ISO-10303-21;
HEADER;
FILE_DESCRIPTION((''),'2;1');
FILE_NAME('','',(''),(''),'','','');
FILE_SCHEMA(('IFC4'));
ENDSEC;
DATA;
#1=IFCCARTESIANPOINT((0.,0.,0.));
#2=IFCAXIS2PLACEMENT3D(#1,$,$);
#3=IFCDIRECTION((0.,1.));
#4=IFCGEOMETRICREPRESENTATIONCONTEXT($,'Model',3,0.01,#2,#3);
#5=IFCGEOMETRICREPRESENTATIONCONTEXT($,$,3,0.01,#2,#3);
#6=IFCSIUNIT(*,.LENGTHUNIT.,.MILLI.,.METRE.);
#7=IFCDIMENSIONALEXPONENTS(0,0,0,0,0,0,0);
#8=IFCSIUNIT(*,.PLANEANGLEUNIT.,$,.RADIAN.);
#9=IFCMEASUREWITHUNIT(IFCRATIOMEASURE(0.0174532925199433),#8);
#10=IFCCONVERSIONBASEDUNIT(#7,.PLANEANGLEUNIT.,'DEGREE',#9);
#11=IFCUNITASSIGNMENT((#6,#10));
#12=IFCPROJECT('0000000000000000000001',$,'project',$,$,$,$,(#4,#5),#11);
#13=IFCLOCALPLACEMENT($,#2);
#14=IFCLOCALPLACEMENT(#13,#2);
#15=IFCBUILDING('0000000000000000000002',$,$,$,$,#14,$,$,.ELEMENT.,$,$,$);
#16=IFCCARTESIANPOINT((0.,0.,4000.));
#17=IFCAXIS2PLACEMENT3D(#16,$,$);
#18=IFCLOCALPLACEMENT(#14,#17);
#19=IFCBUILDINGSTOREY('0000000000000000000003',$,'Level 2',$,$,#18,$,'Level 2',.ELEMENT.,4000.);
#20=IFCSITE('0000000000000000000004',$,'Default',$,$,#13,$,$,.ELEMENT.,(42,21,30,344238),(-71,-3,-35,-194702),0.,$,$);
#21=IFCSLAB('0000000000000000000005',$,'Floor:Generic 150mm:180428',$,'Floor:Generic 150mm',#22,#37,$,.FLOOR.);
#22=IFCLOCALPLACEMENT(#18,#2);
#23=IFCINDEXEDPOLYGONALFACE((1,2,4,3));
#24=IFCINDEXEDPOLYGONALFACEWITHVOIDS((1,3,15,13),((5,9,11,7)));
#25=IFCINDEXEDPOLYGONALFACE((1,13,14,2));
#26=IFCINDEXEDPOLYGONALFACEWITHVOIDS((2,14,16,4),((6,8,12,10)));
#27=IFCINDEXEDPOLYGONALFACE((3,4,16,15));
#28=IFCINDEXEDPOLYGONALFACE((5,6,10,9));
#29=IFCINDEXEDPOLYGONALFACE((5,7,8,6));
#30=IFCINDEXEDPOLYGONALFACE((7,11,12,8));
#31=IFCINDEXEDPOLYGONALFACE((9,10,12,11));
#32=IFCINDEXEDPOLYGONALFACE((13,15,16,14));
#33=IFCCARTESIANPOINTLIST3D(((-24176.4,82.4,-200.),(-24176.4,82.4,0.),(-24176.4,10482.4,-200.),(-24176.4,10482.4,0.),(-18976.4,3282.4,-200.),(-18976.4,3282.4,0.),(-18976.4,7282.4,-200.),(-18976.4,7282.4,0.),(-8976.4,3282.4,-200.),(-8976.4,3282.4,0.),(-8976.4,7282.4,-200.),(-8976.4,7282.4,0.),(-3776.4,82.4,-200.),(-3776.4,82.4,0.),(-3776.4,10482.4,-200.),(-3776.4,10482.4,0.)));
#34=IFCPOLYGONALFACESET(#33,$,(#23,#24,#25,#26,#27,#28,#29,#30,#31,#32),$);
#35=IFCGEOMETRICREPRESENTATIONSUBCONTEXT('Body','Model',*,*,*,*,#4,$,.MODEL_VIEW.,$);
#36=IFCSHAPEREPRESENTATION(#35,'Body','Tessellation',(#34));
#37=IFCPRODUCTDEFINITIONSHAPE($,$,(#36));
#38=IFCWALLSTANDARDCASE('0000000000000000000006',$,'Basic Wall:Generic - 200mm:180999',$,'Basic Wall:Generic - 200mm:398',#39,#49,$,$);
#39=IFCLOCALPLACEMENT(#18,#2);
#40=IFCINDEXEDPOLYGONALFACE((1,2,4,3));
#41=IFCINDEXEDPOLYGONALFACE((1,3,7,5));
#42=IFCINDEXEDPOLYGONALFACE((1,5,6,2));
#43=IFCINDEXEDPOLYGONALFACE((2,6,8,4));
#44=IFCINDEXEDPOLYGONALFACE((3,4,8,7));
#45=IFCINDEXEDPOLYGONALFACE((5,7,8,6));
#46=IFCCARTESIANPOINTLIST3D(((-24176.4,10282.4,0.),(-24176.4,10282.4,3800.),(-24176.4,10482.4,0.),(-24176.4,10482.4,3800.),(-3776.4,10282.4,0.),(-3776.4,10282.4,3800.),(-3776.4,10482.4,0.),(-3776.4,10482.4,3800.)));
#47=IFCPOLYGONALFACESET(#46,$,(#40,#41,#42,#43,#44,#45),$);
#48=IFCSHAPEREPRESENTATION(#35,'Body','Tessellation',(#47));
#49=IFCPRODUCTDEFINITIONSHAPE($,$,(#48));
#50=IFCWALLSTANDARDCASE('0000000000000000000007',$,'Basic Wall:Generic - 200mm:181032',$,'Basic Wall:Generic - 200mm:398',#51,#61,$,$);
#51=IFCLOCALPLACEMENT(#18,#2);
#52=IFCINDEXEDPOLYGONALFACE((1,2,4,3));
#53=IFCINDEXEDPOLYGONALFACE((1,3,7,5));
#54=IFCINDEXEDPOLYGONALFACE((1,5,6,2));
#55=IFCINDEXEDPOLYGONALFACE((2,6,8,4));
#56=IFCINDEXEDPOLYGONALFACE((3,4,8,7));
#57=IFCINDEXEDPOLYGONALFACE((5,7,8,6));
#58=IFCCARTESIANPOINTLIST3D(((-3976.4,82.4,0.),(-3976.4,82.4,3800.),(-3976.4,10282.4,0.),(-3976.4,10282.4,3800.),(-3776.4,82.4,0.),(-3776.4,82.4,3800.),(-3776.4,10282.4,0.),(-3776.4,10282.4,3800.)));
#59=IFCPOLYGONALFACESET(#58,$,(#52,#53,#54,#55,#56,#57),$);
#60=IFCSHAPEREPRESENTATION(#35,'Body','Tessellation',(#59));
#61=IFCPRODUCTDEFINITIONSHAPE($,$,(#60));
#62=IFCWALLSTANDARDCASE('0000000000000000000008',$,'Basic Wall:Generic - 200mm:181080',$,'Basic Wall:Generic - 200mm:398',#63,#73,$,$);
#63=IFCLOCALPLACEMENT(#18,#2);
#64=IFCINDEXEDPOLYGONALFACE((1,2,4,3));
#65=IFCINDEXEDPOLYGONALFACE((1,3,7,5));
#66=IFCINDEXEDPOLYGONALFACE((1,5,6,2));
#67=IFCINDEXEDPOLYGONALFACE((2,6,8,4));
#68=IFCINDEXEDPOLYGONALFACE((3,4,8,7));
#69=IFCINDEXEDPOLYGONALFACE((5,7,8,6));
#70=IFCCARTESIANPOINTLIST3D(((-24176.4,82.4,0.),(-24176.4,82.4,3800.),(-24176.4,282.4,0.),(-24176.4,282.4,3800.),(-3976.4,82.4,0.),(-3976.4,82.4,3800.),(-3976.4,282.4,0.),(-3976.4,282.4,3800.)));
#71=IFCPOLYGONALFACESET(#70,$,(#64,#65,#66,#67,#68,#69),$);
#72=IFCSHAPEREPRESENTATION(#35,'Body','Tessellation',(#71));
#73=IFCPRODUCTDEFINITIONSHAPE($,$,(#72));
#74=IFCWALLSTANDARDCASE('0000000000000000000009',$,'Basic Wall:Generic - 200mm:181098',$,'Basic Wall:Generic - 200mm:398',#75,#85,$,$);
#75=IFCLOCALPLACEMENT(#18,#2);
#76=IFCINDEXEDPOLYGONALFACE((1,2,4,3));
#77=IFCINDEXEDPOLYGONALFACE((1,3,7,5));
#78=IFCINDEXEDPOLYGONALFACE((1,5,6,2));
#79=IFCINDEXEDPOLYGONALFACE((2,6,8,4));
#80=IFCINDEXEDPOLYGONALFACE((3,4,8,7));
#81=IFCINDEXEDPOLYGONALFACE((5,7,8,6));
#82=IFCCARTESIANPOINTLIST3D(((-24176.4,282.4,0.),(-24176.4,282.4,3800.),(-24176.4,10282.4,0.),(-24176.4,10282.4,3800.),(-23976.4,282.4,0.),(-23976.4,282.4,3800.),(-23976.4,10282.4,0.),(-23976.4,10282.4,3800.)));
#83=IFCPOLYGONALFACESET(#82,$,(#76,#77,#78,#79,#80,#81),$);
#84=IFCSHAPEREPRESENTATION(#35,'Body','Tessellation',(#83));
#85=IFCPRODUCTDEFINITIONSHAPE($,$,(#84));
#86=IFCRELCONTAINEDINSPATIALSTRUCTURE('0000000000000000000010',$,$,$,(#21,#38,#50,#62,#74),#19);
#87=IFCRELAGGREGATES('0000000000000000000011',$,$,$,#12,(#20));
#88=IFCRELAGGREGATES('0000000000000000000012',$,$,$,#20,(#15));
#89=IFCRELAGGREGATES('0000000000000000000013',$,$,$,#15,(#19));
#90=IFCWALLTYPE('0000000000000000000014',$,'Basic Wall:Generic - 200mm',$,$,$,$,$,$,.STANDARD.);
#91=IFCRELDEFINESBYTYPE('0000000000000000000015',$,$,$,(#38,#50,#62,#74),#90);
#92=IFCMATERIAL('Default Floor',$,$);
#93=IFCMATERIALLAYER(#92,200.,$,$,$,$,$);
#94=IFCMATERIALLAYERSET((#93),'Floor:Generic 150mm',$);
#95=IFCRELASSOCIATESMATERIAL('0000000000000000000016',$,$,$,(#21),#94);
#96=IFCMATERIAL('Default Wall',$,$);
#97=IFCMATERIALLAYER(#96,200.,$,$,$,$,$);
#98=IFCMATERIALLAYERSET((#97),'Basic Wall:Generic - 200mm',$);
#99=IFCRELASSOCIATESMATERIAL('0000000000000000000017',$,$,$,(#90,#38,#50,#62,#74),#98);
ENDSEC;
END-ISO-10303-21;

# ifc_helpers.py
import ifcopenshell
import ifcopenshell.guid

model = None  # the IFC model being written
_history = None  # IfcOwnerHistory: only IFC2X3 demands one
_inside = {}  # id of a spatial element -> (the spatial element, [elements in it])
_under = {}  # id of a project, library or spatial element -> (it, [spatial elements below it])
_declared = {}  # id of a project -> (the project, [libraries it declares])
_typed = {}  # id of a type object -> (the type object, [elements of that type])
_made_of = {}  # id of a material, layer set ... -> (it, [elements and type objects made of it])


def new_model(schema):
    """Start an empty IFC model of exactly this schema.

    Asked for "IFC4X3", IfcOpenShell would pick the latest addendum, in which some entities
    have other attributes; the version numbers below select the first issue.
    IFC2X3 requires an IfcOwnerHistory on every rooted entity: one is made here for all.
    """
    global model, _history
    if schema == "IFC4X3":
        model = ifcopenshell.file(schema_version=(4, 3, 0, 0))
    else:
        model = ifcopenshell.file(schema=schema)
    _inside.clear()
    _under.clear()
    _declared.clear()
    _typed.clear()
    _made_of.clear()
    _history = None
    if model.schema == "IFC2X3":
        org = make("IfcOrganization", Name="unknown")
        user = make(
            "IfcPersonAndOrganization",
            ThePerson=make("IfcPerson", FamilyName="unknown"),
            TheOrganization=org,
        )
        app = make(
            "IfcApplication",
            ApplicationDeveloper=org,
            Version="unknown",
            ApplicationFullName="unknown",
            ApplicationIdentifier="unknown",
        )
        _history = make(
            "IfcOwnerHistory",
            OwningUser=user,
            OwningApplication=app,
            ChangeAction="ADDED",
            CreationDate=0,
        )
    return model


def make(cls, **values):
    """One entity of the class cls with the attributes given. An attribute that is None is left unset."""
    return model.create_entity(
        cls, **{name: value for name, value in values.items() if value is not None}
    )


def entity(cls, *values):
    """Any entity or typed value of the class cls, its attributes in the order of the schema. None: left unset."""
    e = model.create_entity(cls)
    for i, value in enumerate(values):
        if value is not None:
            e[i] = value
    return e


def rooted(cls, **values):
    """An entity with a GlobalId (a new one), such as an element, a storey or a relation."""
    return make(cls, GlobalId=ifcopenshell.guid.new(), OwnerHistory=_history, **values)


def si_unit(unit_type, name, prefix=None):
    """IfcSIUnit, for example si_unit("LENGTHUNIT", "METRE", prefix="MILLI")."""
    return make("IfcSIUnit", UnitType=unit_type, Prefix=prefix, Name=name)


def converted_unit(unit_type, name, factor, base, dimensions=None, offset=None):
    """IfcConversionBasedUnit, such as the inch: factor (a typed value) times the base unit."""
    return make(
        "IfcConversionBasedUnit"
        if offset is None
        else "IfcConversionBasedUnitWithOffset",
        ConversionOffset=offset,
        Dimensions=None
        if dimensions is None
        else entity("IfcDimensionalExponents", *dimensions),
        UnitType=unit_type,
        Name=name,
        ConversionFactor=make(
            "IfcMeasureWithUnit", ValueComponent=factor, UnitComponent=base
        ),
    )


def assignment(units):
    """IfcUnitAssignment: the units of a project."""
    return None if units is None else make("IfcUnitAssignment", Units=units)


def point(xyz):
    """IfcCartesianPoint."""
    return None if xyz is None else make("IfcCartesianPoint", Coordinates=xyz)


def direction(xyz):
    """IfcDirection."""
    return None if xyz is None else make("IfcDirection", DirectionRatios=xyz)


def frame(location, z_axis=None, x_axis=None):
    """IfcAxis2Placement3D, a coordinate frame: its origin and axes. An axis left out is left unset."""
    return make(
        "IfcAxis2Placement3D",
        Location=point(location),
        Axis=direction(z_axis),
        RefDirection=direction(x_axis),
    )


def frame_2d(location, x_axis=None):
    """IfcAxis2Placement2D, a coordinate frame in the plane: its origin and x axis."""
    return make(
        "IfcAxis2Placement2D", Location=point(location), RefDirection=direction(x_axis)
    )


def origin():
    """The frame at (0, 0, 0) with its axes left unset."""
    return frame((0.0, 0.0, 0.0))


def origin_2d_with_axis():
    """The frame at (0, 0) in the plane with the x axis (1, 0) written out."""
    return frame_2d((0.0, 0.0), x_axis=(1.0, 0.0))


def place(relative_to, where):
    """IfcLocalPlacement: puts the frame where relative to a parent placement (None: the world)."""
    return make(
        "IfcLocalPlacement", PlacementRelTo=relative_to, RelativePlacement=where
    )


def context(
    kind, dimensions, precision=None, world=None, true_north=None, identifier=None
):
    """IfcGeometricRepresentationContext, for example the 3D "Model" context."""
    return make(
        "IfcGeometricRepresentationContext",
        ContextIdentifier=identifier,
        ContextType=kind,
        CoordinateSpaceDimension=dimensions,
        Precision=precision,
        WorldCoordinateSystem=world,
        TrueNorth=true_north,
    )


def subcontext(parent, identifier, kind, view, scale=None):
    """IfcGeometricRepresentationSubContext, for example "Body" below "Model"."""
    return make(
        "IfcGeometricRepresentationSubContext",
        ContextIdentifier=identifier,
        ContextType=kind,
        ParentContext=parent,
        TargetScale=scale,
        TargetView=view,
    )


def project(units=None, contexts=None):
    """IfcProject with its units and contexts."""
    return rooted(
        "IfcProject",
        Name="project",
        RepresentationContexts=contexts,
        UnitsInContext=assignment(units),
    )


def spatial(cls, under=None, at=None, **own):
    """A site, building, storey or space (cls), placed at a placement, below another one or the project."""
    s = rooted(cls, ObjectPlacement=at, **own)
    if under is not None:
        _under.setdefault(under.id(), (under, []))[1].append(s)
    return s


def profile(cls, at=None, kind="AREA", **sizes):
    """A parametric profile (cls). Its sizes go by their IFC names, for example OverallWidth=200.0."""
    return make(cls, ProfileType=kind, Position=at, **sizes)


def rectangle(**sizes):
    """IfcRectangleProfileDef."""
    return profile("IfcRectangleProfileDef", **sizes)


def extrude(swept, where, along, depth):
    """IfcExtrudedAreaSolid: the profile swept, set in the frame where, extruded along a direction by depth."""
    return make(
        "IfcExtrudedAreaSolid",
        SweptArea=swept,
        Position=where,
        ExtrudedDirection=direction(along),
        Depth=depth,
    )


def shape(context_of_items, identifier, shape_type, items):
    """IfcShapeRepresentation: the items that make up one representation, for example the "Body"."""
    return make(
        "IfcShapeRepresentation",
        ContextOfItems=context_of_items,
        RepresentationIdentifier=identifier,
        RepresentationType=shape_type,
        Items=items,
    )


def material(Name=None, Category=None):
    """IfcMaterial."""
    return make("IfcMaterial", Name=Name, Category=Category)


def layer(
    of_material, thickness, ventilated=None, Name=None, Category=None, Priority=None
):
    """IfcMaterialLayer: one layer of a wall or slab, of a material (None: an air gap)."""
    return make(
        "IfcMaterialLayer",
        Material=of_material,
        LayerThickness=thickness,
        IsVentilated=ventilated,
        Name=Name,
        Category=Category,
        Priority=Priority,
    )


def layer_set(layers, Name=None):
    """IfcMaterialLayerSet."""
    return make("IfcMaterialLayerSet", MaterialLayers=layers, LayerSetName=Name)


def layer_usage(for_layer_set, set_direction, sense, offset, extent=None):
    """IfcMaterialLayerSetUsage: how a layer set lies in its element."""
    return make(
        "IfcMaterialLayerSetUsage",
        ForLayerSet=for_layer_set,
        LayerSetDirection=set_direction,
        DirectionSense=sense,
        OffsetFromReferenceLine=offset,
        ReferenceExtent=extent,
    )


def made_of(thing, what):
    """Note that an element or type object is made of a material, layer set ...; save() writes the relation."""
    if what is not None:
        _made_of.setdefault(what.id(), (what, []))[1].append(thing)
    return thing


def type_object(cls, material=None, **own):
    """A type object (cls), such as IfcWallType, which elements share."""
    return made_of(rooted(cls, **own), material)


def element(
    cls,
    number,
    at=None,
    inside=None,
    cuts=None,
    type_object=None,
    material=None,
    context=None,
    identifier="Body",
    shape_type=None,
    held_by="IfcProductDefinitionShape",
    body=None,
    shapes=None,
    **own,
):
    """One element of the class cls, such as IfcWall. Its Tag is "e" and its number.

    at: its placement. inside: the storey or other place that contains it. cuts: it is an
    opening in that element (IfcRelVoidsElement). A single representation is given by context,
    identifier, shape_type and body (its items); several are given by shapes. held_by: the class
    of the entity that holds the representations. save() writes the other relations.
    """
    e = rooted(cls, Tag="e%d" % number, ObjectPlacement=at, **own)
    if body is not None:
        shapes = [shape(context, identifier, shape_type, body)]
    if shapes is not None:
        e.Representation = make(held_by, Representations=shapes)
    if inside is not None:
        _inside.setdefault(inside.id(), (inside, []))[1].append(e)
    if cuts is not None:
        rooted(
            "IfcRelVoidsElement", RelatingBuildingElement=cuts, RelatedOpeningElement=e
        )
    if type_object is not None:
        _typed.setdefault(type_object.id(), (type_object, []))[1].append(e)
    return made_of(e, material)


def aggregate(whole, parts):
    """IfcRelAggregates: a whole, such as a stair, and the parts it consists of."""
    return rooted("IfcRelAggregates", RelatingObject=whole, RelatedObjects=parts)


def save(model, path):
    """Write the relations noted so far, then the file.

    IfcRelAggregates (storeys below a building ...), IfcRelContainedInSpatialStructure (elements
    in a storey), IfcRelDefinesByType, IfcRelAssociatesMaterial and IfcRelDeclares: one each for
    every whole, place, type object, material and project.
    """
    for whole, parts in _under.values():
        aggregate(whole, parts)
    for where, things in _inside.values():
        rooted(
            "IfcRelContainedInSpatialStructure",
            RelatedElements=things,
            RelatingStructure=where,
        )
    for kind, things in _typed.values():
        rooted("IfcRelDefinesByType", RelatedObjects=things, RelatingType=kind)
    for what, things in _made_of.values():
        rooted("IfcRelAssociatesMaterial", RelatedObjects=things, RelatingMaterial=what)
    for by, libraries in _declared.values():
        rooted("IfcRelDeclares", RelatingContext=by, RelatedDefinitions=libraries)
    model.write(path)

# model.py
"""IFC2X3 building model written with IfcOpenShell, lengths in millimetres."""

from ifc_helpers import new_model, entity, si_unit, converted_unit, direction, frame, frame_2d, origin, origin_2d_with_axis, place, context, subcontext, project, spatial, rectangle, extrude, material, layer, layer_set, layer_usage, type_object, element, save


model = new_model("IFC2X3")

# Units and contexts
model_context = context("Model", 3, precision=0.01, world=origin(), true_north=direction((0.0, 1.0)))
context_of_model = context(None, 3, precision=0.01, world=origin(), true_north=direction((0.0, 1.0)))
body_context = subcontext(model_context, "Body", "Model", "MODEL_VIEW")
ifc_project = project(units=[si_unit("LENGTHUNIT", "METRE", prefix="MILLI"), converted_unit("PLANEANGLEUNIT", "DEGREE", entity("IfcRatioMeasure", 0.0174532925199433), si_unit("PLANEANGLEUNIT", "RADIAN"), dimensions=[0, 0, 0, 0, 0, 0, 0])], contexts=[model_context, context_of_model])

# Site, building, storey
site_placement = place(None, origin())
site = spatial("IfcSite", under=ifc_project, at=site_placement, Name="Default", CompositionType="ELEMENT", RefLatitude=(42, 21, 30, 344238), RefLongitude=(-71, -3, -35, -194702), RefElevation=0.0)
building_placement = place(site_placement, origin())
building = spatial("IfcBuilding", under=site, at=building_placement, CompositionType="ELEMENT")
storey_placement = place(building_placement, frame((0.0, 0.0, 4000.0)))
storey = spatial("IfcBuildingStorey", under=building, at=storey_placement, Name="Level 2", LongName="Level 2", CompositionType="ELEMENT", Elevation=4000.0)

# Slab, opening
ifc_material_1 = material(Name="Default Floor")
ifc_layer_1 = layer(ifc_material_1, 200.0)
ifc_layer_set_1 = layer_set([ifc_layer_1], Name="Floor:Generic 150mm")
ifc_layer_usage_1 = layer_usage(ifc_layer_set_1, "AXIS3", "POSITIVE", 0.0)
slab_placement = place(storey_placement, frame((-24176.4, 82.4, -200.0)))
slab = element("IfcSlab", 1, at=slab_placement, inside=storey, material=ifc_layer_usage_1, Name="Floor:Generic 150mm:180428", ObjectType="Floor:Generic 150mm", PredefinedType="FLOOR", context=body_context, shape_type="SweptSolid", body=[
    extrude(rectangle(XDim=10400.0, YDim=20400.0, at=frame_2d((0.0, 0.0), x_axis=(0.0, -1.0))), frame((10200.0, 5200.0, 200.0), z_axis=(0.0, 0.0, -1.0), x_axis=(-1.0, 0.0, 0.0)), (0.0, 0.0, 1.0), 200.0),
])
opening_placement = place(slab_placement, frame((10200.0, 5200.0, 200.0)))
element("IfcOpeningElement", 2, at=opening_placement, cuts=slab, ObjectType="Opening", context=body_context, shape_type="SweptSolid", body=[
    extrude(rectangle(XDim=4000.0, YDim=10000.0, at=origin_2d_with_axis()), frame((0.0, 0.0, 0.0), z_axis=(0.0, 0.0, 1.0), x_axis=(0.0, -1.0, 0.0)), (0.0, 0.0, -1.0), 200.0),
])

# Walls
ifc_material_2 = material(Name="Default Wall")
ifc_layer_2 = layer(ifc_material_2, 200.0)
ifc_layer_set_2 = layer_set([ifc_layer_2], Name="Basic Wall:Generic - 200mm")
ifc_layer_usage_2 = layer_usage(ifc_layer_set_2, "AXIS2", "NEGATIVE", 100.0)
wall_type = type_object("IfcWallType", Name="Basic Wall:Generic - 200mm", PredefinedType="STANDARD", material=ifc_layer_set_2)
wall_1_placement = place(storey_placement, frame((-24176.4, 10382.4, 0.0)))
element("IfcWallStandardCase", 3, at=wall_1_placement, inside=storey, type_object=wall_type, material=ifc_layer_usage_2, Name="Basic Wall:Generic - 200mm:180999", ObjectType="Basic Wall:Generic - 200mm:398", context=body_context, shape_type="SweptSolid", body=[
    extrude(rectangle(XDim=20400.0, YDim=200.0, at=frame_2d((10200.0, 0.0), x_axis=(-1.0, 0.0))), origin(), (0.0, 0.0, 1.0), 3800.0),
])
ifc_layer_usage_3 = layer_usage(ifc_layer_set_2, "AXIS2", "NEGATIVE", 100.0)
wall_2_placement = place(storey_placement, frame((-3876.4, 10282.4, 0.0), z_axis=(0.0, 0.0, 1.0), x_axis=(0.0, -1.0, 0.0)))
element("IfcWallStandardCase", 4, at=wall_2_placement, inside=storey, type_object=wall_type, material=ifc_layer_usage_3, Name="Basic Wall:Generic - 200mm:181032", ObjectType="Basic Wall:Generic - 200mm:398", context=body_context, shape_type="SweptSolid", body=[
    extrude(rectangle(XDim=10200.0, YDim=200.0, at=frame_2d((5100.0, 0.0), x_axis=(-1.0, 0.0))), origin(), (0.0, 0.0, 1.0), 3800.0),
])
ifc_layer_usage_4 = layer_usage(ifc_layer_set_2, "AXIS2", "NEGATIVE", 100.0)
wall_3_placement = place(storey_placement, frame((-3976.4, 182.4, 0.0), z_axis=(0.0, 0.0, 1.0), x_axis=(-1.0, 0.0, 0.0)))
element("IfcWallStandardCase", 5, at=wall_3_placement, inside=storey, type_object=wall_type, material=ifc_layer_usage_4, Name="Basic Wall:Generic - 200mm:181080", ObjectType="Basic Wall:Generic - 200mm:398", context=body_context, shape_type="SweptSolid", body=[
    extrude(rectangle(XDim=20200.0, YDim=200.0, at=frame_2d((10100.0, 0.0), x_axis=(-1.0, 0.0))), origin(), (0.0, 0.0, 1.0), 3800.0),
])
ifc_layer_usage_5 = layer_usage(ifc_layer_set_2, "AXIS2", "NEGATIVE", 100.0)
wall_4_placement = place(storey_placement, frame((-24076.4, 282.4, 0.0), z_axis=(0.0, 0.0, 1.0), x_axis=(0.0, 1.0, 0.0)))
element("IfcWallStandardCase", 6, at=wall_4_placement, inside=storey, type_object=wall_type, material=ifc_layer_usage_5, Name="Basic Wall:Generic - 200mm:181098", ObjectType="Basic Wall:Generic - 200mm:398", context=body_context, shape_type="SweptSolid", body=[
    extrude(rectangle(XDim=10000.0, YDim=200.0, at=frame_2d((5000.0, 0.0), x_axis=(-1.0, 0.0))), origin(), (0.0, 0.0, 1.0), 3800.0),
])

save(model, "model.ifc")
